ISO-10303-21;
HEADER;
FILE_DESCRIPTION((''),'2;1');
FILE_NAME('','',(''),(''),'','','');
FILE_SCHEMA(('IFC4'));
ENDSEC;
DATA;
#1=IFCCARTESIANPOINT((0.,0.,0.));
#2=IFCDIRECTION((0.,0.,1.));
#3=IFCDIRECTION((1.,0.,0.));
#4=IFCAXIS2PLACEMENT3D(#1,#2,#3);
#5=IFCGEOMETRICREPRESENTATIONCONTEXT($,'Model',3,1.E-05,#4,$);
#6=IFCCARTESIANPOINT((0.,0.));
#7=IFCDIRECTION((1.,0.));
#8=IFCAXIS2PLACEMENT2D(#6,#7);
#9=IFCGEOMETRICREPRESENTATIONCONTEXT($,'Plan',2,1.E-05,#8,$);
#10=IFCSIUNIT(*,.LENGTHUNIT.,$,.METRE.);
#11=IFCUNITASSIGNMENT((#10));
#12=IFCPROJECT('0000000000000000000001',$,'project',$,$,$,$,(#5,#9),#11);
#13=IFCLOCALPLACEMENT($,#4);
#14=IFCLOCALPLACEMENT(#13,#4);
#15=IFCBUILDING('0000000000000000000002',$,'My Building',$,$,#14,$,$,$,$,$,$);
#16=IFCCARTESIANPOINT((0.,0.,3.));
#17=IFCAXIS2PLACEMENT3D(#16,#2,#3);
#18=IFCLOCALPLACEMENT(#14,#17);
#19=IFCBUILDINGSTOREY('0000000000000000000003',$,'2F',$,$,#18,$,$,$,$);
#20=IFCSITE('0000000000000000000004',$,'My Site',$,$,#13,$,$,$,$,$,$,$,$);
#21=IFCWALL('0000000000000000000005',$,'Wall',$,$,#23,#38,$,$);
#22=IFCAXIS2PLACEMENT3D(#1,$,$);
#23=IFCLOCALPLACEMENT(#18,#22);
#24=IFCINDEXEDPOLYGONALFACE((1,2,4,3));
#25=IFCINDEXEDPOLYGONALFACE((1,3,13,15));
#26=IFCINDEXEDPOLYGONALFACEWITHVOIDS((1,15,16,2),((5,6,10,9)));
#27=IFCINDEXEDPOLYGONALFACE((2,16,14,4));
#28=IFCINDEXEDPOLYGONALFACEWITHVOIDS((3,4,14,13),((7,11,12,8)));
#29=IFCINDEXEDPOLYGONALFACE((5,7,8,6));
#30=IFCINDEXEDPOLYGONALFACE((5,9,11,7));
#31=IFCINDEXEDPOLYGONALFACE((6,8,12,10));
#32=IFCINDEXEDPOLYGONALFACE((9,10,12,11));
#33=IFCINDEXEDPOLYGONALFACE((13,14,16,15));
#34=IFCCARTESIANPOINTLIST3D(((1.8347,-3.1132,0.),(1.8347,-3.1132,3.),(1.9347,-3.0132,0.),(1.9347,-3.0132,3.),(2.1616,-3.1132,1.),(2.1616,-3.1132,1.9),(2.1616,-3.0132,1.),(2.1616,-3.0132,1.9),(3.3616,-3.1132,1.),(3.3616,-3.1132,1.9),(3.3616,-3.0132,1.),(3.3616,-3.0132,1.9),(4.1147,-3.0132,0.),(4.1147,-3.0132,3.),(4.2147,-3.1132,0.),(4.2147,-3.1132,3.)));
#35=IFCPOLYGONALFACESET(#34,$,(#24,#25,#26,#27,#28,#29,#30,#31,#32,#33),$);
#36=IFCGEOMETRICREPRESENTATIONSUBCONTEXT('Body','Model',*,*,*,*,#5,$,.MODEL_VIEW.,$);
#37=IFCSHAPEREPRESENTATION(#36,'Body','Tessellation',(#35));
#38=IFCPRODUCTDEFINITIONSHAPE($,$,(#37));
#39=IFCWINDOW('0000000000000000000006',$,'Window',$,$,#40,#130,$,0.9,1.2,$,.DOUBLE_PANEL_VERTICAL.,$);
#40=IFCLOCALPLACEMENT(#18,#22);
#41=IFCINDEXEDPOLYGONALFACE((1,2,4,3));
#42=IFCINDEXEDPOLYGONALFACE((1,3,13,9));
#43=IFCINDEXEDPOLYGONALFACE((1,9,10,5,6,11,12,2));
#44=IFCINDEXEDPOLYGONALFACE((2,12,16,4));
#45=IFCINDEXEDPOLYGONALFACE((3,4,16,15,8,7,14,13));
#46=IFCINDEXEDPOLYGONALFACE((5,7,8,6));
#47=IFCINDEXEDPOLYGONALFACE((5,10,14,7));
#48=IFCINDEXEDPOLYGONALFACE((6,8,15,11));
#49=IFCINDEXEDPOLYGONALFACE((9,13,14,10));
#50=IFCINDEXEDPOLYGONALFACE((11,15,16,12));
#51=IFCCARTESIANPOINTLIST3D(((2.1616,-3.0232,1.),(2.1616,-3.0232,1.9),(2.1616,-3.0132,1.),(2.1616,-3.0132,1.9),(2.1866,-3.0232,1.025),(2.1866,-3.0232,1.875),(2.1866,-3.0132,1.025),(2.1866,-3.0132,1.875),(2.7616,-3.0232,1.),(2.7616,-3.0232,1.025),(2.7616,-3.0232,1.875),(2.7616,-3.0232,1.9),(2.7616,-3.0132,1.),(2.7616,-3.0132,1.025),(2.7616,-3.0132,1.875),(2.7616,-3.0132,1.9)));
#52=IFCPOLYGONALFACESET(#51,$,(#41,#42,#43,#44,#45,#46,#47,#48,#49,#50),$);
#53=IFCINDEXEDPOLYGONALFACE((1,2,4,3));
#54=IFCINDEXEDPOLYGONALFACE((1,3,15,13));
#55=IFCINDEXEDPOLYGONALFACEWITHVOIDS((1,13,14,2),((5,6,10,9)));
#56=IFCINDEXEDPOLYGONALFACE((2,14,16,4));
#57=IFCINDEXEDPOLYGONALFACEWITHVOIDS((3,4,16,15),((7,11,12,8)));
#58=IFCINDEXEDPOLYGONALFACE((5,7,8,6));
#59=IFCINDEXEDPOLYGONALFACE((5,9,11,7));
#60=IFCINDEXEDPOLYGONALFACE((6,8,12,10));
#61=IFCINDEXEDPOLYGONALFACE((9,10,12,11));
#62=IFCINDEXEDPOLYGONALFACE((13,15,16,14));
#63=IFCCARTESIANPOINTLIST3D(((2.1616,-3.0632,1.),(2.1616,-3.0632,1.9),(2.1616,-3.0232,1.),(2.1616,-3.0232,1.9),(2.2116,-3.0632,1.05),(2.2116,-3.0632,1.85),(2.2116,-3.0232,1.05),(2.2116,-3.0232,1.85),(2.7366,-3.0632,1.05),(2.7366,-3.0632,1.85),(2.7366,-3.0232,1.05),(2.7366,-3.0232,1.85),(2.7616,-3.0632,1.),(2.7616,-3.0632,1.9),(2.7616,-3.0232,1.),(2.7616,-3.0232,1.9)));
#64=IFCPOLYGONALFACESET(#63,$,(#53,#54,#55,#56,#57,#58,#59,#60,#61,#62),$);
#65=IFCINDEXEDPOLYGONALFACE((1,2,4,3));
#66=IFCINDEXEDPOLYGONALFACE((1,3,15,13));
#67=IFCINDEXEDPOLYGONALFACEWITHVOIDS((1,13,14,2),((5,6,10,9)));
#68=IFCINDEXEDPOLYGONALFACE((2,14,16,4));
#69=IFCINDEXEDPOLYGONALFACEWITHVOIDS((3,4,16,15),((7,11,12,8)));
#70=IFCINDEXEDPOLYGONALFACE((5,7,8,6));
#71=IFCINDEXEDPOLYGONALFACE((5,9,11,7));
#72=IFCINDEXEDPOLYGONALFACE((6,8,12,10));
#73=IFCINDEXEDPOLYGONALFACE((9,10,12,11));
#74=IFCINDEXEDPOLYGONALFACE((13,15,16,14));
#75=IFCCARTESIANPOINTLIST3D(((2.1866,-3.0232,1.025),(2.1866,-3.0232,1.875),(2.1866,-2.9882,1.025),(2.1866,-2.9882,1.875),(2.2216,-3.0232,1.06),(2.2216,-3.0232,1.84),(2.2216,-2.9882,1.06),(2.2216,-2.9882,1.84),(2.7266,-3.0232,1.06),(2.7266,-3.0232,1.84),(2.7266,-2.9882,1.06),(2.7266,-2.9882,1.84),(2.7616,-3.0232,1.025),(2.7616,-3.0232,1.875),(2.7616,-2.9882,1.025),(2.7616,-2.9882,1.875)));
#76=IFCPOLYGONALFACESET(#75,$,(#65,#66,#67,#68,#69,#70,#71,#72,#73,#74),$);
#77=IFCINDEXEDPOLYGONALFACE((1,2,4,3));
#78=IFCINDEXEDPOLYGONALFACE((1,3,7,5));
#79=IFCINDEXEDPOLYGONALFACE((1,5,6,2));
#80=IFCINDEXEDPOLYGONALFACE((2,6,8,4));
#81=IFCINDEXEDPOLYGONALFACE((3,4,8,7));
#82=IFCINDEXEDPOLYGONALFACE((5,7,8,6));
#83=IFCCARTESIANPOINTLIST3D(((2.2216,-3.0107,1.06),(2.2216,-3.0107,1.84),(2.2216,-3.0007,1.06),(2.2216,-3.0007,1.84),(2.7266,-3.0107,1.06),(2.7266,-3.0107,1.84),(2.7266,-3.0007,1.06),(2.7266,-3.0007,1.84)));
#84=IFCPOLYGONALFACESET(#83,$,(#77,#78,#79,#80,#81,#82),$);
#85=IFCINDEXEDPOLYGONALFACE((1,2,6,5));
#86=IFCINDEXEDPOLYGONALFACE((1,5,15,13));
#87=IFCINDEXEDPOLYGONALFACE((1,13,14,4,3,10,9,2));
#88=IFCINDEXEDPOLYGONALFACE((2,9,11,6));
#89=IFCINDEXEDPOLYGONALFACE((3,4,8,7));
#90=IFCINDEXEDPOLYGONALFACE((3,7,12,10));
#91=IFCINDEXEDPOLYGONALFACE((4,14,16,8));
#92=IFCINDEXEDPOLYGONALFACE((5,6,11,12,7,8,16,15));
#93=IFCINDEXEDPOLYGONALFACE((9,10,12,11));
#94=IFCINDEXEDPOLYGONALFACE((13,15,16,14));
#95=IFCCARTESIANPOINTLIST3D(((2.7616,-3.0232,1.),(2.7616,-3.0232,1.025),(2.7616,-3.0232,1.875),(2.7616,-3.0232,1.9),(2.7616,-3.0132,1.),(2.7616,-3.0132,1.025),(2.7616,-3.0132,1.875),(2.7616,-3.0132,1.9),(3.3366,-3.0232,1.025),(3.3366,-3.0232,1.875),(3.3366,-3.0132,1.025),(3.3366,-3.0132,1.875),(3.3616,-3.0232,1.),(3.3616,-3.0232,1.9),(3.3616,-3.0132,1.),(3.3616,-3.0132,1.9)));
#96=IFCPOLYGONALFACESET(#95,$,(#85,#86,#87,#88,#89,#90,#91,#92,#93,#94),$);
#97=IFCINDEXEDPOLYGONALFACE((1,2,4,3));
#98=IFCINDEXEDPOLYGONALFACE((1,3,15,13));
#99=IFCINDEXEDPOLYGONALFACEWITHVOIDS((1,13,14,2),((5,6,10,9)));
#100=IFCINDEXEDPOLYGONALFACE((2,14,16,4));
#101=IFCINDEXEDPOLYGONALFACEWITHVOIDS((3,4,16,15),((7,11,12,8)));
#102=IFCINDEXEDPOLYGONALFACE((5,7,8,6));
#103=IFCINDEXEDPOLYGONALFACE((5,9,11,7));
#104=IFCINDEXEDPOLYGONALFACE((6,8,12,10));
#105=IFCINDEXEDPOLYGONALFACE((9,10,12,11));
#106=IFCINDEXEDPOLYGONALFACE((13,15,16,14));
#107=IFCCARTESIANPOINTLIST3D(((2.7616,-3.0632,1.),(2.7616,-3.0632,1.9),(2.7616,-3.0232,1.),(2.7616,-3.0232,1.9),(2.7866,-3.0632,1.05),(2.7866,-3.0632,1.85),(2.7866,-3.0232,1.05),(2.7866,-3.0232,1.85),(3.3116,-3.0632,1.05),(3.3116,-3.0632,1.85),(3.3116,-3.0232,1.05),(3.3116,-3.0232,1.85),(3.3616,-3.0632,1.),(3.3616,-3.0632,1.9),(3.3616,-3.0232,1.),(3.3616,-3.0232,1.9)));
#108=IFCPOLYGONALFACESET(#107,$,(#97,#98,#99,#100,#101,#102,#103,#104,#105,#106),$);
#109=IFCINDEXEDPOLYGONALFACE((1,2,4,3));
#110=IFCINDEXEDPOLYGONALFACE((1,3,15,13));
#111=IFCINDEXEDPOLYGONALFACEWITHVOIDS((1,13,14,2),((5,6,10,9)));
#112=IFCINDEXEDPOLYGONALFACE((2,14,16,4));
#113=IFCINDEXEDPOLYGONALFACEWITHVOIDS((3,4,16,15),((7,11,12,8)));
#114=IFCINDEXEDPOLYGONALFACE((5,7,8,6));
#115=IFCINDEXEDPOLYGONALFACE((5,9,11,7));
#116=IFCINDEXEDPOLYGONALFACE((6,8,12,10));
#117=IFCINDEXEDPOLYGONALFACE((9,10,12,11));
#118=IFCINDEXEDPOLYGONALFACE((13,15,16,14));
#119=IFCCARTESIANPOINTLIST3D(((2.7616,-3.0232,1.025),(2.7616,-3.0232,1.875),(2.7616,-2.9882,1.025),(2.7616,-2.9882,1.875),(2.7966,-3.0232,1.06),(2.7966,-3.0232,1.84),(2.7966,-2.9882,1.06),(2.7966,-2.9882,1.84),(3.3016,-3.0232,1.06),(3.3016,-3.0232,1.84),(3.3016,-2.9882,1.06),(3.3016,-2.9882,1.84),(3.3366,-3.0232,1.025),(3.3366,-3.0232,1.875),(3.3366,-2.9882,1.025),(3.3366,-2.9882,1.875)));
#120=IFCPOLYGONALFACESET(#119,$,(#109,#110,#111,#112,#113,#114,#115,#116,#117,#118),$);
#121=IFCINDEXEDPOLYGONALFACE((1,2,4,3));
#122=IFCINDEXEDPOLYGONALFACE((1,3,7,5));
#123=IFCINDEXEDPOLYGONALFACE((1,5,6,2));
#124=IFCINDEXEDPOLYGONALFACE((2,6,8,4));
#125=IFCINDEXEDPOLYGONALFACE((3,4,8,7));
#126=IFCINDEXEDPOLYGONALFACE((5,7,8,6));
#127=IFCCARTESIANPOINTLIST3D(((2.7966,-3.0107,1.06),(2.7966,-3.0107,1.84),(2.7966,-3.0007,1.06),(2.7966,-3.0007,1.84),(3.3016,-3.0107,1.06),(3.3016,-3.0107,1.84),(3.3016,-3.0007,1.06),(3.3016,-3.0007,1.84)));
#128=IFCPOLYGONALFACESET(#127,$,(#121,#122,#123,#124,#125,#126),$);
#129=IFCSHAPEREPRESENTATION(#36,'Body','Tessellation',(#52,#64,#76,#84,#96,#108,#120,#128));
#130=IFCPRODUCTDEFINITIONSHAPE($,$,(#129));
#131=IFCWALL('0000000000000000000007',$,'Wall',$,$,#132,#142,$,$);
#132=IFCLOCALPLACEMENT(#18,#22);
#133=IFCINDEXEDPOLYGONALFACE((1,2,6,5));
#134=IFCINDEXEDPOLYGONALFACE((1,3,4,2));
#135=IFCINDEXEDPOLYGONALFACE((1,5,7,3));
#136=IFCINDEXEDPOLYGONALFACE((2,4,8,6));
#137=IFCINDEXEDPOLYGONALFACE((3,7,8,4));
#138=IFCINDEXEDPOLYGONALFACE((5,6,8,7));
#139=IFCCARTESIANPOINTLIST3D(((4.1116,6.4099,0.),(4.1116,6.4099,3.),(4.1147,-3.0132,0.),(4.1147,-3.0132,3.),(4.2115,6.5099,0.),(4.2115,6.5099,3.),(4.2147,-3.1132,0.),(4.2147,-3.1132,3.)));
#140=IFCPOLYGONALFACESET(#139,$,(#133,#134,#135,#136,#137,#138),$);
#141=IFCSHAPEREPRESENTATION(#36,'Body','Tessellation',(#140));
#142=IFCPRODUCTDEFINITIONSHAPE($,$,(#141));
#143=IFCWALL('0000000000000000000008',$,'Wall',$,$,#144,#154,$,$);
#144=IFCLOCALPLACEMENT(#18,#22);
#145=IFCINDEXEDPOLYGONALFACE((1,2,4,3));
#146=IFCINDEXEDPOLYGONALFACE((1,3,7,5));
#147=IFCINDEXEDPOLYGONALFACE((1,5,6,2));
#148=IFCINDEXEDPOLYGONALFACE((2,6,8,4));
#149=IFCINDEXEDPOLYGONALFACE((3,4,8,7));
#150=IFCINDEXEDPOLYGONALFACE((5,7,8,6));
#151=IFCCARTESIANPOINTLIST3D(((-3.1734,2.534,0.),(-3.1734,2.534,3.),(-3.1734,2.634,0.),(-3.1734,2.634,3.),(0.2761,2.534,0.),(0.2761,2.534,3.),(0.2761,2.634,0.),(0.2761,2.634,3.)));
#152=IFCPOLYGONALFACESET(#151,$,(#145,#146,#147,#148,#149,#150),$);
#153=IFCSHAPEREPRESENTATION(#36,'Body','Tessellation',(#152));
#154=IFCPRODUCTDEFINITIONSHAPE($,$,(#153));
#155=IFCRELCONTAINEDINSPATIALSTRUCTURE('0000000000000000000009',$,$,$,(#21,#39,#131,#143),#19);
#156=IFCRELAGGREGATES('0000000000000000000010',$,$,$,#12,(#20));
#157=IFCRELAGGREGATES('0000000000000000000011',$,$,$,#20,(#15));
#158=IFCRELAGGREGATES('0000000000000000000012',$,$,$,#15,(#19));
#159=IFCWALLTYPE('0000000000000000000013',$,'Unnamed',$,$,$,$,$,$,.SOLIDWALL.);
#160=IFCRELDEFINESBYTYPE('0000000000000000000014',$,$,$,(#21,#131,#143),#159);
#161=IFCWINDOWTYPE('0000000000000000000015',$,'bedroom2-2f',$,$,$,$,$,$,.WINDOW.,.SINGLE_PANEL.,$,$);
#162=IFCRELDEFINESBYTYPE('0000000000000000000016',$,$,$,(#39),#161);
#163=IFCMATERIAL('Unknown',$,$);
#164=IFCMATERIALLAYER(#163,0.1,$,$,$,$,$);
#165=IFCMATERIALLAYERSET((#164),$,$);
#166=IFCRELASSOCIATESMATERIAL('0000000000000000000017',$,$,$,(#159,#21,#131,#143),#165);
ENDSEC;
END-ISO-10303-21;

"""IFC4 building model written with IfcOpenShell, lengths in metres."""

from ifc_helpers import new_model, entity, si_unit, frame, origin_with_axes, origin_2d_with_axis, place, context, subcontext, project, spatial, line, indexed_curve, outline, extrude, shape, source, transform, mapped, material, layer, layer_set, layer_usage, type_object, type_shapes, element, fill, save


model = new_model("IFC4")

# Units and contexts
model_context = context("Model", 3, precision=1e-05, world=origin_with_axes())
plan_context = context("Plan", 2, precision=1e-05, world=origin_2d_with_axis())
body_context_1 = subcontext(model_context, "Body", "Model", "MODEL_VIEW")
body_context_2 = subcontext(plan_context, "Body", "Plan", "PLAN_VIEW")
ifc_project = project(units=[si_unit("LENGTHUNIT", "METRE")], contexts=[model_context, plan_context])

# Site, building, storey
site_placement = place(None, origin_with_axes())
site = spatial("IfcSite", under=ifc_project, at=site_placement, Name="My Site")
building_placement = place(site_placement, origin_with_axes())
building = spatial("IfcBuilding", under=site, at=building_placement, Name="My Building")
storey_placement = place(building_placement, frame((0.0, 0.0, 3.0), z_axis=(0.0, 0.0, 1.0), x_axis=(1.0, 0.0, 0.0)))
storey = spatial("IfcBuildingStorey", under=building, at=storey_placement, Name="2F")

# Shared definitions
ifc_material = material(Name="Unknown")

# Shared definitions
ifc_layer_1 = layer(ifc_material, 0.1)
ifc_layer_set_1 = layer_set([ifc_layer_1])
wall_type = type_object("IfcWallType", Name="Unnamed", PredefinedType="SOLIDWALL", material=ifc_layer_set_1)

# Wall, opening, window
ifc_layer_usage_1 = layer_usage(ifc_layer_set_1, "AXIS2", "POSITIVE", 0.0)
wall_1_placement = place(storey_placement, frame((1.8347, -3.1132, 0.0), z_axis=(0.0, 0.0, 1.0), x_axis=(1.0, 0.0, 0.0)))
wall_1 = element("IfcWall", 1, at=wall_1_placement, inside=storey, type_object=wall_type, material=ifc_layer_usage_1, Name="Wall", context=body_context_1, shape_type="SweptSolid", body=[
    extrude(outline(indexed_curve([(0.0, 0.0), (0.1, 0.1), (2.28, 0.1), (2.38, 0.0)], segments=[line(1, 2, 3, 4, 1)])), origin_with_axes(), (0.0, 0.0, 1.0), 3.0),
])
shared_shape_1 = source(origin_with_axes(), body_context_1, "Body", "SweptSolid", [
    extrude(outline(indexed_curve([(0.0, 0.0), (1.2, 0.0), (1.2, 0.9), (0.0, 0.9)], segments=[line(1, 2, 3, 4, 1)])), frame((0.0, -0.6, 0.0), z_axis=(0.0, -1.0, 0.0), x_axis=(1.0, 0.0, 0.0)), (0.0, 0.0, -1.0), 1.2),
])
opening_1_placement = place(wall_1_placement, frame((0.3268, 0.0, 1.0), z_axis=(0.0, 0.0, 1.0), x_axis=(1.0, 0.0, 0.0)))
opening_1 = element("IfcOpeningElement", 2, at=opening_1_placement, cuts=wall_1, PredefinedType="OPENING", context=body_context_1, shape_type="MappedRepresentation", body=[
    mapped(shared_shape_1, transform((0.0, 0.0, 0.0), x_axis=(1.0, 0.0, 0.0), y_axis=(0.0, 1.0, 0.0), z_axis=(0.0, 0.0, 1.0), scale=1.0)),
])
window_type_1 = type_object("IfcWindowType", Name="bedroom2-2f", PartitioningType="SINGLE_PANEL", PredefinedType="WINDOW")
shared_shape_2 = source(origin_with_axes(), body_context_1, "Body", "SweptSolid", [
    extrude(outline(indexed_curve([(0.6, 0.0), (0.0, 0.0), (0.0, 0.9), (0.6, 0.9), (0.6, 0.875), (0.025, 0.875), (0.025, 0.025), (0.6, 0.025)], segments=[line(1, 2, 3, 4, 5, 6, 7, 8, 1)])), frame((0.0, 0.09, 0.0), z_axis=(0.0, -1.0, 0.0), x_axis=(1.0, 0.0, 0.0)), (0.0, 0.0, -1.0), 0.01),
    extrude(outline(indexed_curve([(0.0, 0.0), (0.6, 0.0), (0.6, 0.9), (0.0, 0.9)], segments=[line(1, 2, 3, 4, 1)]), holes=[indexed_curve([(0.05, 0.05), (0.575, 0.05), (0.575, 0.85), (0.05, 0.85)], segments=[line(1, 2, 3, 4, 1)])]), frame((0.0, 0.05, 0.0), z_axis=(0.0, -1.0, 0.0), x_axis=(1.0, 0.0, 0.0)), (0.0, 0.0, -1.0), 0.04),
    extrude(outline(indexed_curve([(0.0, 0.0), (0.575, 0.0), (0.575, 0.85), (0.0, 0.85)], segments=[line(1, 2, 3, 4, 1)]), holes=[indexed_curve([(0.035, 0.035), (0.54, 0.035), (0.54, 0.815), (0.035, 0.815)], segments=[line(1, 2, 3, 4, 1)])]), frame((0.025, 0.09, 0.025), z_axis=(0.0, -1.0, 0.0), x_axis=(1.0, 0.0, 0.0)), (0.0, 0.0, -1.0), 0.035),
    extrude(outline(indexed_curve([(0.035, 0.035), (0.54, 0.035), (0.54, 0.815), (0.035, 0.815)], segments=[line(1, 2, 3, 4, 1)])), frame((0.025, 0.1025, 0.025), z_axis=(0.0, -1.0, 0.0), x_axis=(1.0, 0.0, 0.0)), (0.0, 0.0, -1.0), 0.01),
    extrude(outline(indexed_curve([(0.0, 0.9), (0.6, 0.9), (0.6, 0.0), (0.0, 0.0), (0.0, 0.025), (0.575, 0.025), (0.575, 0.875), (0.0, 0.875)], segments=[line(1, 2, 3, 4, 5, 6, 7, 8, 1)])), frame((0.6, 0.09, 0.0), z_axis=(0.0, -1.0, 0.0), x_axis=(1.0, 0.0, 0.0)), (0.0, 0.0, -1.0), 0.01),
    extrude(outline(indexed_curve([(0.0, 0.0), (0.6, 0.0), (0.6, 0.9), (0.0, 0.9)], segments=[line(1, 2, 3, 4, 1)]), holes=[indexed_curve([(0.025, 0.05), (0.55, 0.05), (0.55, 0.85), (0.025, 0.85)], segments=[line(1, 2, 3, 4, 1)])]), frame((0.6, 0.05, 0.0), z_axis=(0.0, -1.0, 0.0), x_axis=(1.0, 0.0, 0.0)), (0.0, 0.0, -1.0), 0.04),
    extrude(outline(indexed_curve([(0.0, 0.0), (0.575, 0.0), (0.575, 0.85), (0.0, 0.85)], segments=[line(1, 2, 3, 4, 1)]), holes=[indexed_curve([(0.035, 0.035), (0.54, 0.035), (0.54, 0.815), (0.035, 0.815)], segments=[line(1, 2, 3, 4, 1)])]), frame((0.6, 0.09, 0.025), z_axis=(0.0, -1.0, 0.0), x_axis=(1.0, 0.0, 0.0)), (0.0, 0.0, -1.0), 0.035),
    extrude(outline(indexed_curve([(0.035, 0.035), (0.54, 0.035), (0.54, 0.815), (0.035, 0.815)], segments=[line(1, 2, 3, 4, 1)])), frame((0.6, 0.1025, 0.025), z_axis=(0.0, -1.0, 0.0), x_axis=(1.0, 0.0, 0.0)), (0.0, 0.0, -1.0), 0.01),
])
shared_shape_3 = source(origin_with_axes(), body_context_2, "Body", "Curve2D", [
    entity("IfcIndexedPolyCurve", entity("IfcCartesianPointList2D", [[0.05, 0.05], [0.575, 0.05]])),
    entity("IfcIndexedPolyCurve", entity("IfcCartesianPointList2D", [[0.0, 0.1], [0.025, 0.1], [0.025, 0.09], [0.05, 0.09], [0.05, 0.05], [0.0, 0.05]]), [entity("IfcLineIndex", [1, 2, 3, 4, 5, 6, 1])]),
    entity("IfcIndexedPolyCurve", entity("IfcCartesianPointList2D", [[0.6, 0.1], [0.6, 0.1], [0.6, 0.09], [0.575, 0.09], [0.575, 0.05], [0.6, 0.05]])),
    entity("IfcIndexedPolyCurve", entity("IfcCartesianPointList2D", [[0.025, 0.09], [0.06, 0.09], [0.06, 0.125], [0.025, 0.125]]), [entity("IfcLineIndex", [1, 2, 3, 4, 1])]),
    entity("IfcIndexedPolyCurve", entity("IfcCartesianPointList2D", [[0.6, 0.09], [0.565, 0.09], [0.565, 0.125], [0.6, 0.125]]), [entity("IfcLineIndex", [1, 2, 3, 4, 1])]),
    entity("IfcIndexedPolyCurve", entity("IfcCartesianPointList2D", [[0.06, 0.09], [0.565, 0.09]])),
    entity("IfcIndexedPolyCurve", entity("IfcCartesianPointList2D", [[0.06, 0.125], [0.565, 0.125]])),
    entity("IfcIndexedPolyCurve", entity("IfcCartesianPointList2D", [[0.06, 0.1075], [0.565, 0.1075]])),
    entity("IfcIndexedPolyCurve", entity("IfcCartesianPointList2D", [[0.625, 0.05], [1.15, 0.05]])),
    entity("IfcIndexedPolyCurve", entity("IfcCartesianPointList2D", [[0.6, 0.1], [0.6, 0.1], [0.6, 0.09], [0.625, 0.09], [0.625, 0.05], [0.6, 0.05]])),
    entity("IfcIndexedPolyCurve", entity("IfcCartesianPointList2D", [[1.2, 0.1], [1.175, 0.1], [1.175, 0.09], [1.15, 0.09], [1.15, 0.05], [1.2, 0.05]]), [entity("IfcLineIndex", [1, 2, 3, 4, 5, 6, 1])]),
    entity("IfcIndexedPolyCurve", entity("IfcCartesianPointList2D", [[0.6, 0.09], [0.635, 0.09], [0.635, 0.125], [0.6, 0.125]]), [entity("IfcLineIndex", [1, 2, 3, 4, 1])]),
    entity("IfcIndexedPolyCurve", entity("IfcCartesianPointList2D", [[1.175, 0.09], [1.14, 0.09], [1.14, 0.125], [1.175, 0.125]]), [entity("IfcLineIndex", [1, 2, 3, 4, 1])]),
    entity("IfcIndexedPolyCurve", entity("IfcCartesianPointList2D", [[0.635, 0.09], [1.14, 0.09]])),
    entity("IfcIndexedPolyCurve", entity("IfcCartesianPointList2D", [[0.635, 0.125], [1.14, 0.125]])),
    entity("IfcIndexedPolyCurve", entity("IfcCartesianPointList2D", [[0.635, 0.1075], [1.14, 0.1075]])),
])
type_shapes(window_type_1, [shared_shape_2, shared_shape_3])
window_1_placement = place(opening_1_placement, frame((0.0, 0.0, 0.0), z_axis=(0.0, 0.0, 1.0), x_axis=(1.0, 0.0, 0.0)))
window_1 = element("IfcWindow", 3, at=window_1_placement, inside=storey, type_object=window_type_1, Name="Window", OverallHeight=0.9, OverallWidth=1.2, PartitioningType="DOUBLE_PANEL_VERTICAL", shapes=[
    shape(body_context_1, "Body", "MappedRepresentation", [mapped(shared_shape_2, transform((0.0, 0.0, 0.0), x_axis=(1.0, 0.0, 0.0), y_axis=(0.0, 1.0, 0.0), z_axis=(0.0, 0.0, 1.0), scale=1.0))]),
    shape(body_context_2, "Body", "MappedRepresentation", [mapped(shared_shape_3, transform((0.0, 0.0, 0.0), x_axis=(1.0, 0.0, 0.0), y_axis=(0.0, 1.0, 0.0), z_axis=(0.0, 0.0, 1.0), scale=1.0))]),
])
fill(opening_1, window_1)

# Wall
ifc_layer_usage_2 = layer_usage(ifc_layer_set_1, "AXIS2", "POSITIVE", 0.0)
wall_2_placement = place(storey_placement, frame((4.2147, -3.1132, 0.0), z_axis=(0.0, 0.0, 1.0), x_axis=(-0.000331, 1.0, 0.0)))
element("IfcWall", 4, at=wall_2_placement, inside=storey, type_object=wall_type, material=ifc_layer_usage_2, Name="Wall", context=body_context_1, shape_type="SweptSolid", body=[
    extrude(outline(indexed_curve([(0.0, 0.0), (0.1, 0.1), (9.5231, 0.1), (9.6231, 0.0)], segments=[line(1, 2, 3, 4, 1)])), origin_with_axes(), (0.0, 0.0, 1.0), 3.0),
])

# Wall
ifc_layer_usage_3 = layer_usage(ifc_layer_set_1, "AXIS2", "POSITIVE", 0.0)
wall_3_placement = place(storey_placement, frame((-3.1734, 2.534, 0.0), z_axis=(0.0, 0.0, 1.0), x_axis=(1.0, 0.0, 0.0)))
element("IfcWall", 5, at=wall_3_placement, inside=storey, type_object=wall_type, material=ifc_layer_usage_3, Name="Wall", context=body_context_1, shape_type="SweptSolid", body=[
    extrude(outline(indexed_curve([(0.0, 0.0), (0.0, 0.1), (3.4495, 0.1), (3.4495, 0.0)], segments=[line(1, 2, 3, 4, 1)])), origin_with_axes(), (0.0, 0.0, 1.0), 3.0),
])

save(model, "model.ifc")
